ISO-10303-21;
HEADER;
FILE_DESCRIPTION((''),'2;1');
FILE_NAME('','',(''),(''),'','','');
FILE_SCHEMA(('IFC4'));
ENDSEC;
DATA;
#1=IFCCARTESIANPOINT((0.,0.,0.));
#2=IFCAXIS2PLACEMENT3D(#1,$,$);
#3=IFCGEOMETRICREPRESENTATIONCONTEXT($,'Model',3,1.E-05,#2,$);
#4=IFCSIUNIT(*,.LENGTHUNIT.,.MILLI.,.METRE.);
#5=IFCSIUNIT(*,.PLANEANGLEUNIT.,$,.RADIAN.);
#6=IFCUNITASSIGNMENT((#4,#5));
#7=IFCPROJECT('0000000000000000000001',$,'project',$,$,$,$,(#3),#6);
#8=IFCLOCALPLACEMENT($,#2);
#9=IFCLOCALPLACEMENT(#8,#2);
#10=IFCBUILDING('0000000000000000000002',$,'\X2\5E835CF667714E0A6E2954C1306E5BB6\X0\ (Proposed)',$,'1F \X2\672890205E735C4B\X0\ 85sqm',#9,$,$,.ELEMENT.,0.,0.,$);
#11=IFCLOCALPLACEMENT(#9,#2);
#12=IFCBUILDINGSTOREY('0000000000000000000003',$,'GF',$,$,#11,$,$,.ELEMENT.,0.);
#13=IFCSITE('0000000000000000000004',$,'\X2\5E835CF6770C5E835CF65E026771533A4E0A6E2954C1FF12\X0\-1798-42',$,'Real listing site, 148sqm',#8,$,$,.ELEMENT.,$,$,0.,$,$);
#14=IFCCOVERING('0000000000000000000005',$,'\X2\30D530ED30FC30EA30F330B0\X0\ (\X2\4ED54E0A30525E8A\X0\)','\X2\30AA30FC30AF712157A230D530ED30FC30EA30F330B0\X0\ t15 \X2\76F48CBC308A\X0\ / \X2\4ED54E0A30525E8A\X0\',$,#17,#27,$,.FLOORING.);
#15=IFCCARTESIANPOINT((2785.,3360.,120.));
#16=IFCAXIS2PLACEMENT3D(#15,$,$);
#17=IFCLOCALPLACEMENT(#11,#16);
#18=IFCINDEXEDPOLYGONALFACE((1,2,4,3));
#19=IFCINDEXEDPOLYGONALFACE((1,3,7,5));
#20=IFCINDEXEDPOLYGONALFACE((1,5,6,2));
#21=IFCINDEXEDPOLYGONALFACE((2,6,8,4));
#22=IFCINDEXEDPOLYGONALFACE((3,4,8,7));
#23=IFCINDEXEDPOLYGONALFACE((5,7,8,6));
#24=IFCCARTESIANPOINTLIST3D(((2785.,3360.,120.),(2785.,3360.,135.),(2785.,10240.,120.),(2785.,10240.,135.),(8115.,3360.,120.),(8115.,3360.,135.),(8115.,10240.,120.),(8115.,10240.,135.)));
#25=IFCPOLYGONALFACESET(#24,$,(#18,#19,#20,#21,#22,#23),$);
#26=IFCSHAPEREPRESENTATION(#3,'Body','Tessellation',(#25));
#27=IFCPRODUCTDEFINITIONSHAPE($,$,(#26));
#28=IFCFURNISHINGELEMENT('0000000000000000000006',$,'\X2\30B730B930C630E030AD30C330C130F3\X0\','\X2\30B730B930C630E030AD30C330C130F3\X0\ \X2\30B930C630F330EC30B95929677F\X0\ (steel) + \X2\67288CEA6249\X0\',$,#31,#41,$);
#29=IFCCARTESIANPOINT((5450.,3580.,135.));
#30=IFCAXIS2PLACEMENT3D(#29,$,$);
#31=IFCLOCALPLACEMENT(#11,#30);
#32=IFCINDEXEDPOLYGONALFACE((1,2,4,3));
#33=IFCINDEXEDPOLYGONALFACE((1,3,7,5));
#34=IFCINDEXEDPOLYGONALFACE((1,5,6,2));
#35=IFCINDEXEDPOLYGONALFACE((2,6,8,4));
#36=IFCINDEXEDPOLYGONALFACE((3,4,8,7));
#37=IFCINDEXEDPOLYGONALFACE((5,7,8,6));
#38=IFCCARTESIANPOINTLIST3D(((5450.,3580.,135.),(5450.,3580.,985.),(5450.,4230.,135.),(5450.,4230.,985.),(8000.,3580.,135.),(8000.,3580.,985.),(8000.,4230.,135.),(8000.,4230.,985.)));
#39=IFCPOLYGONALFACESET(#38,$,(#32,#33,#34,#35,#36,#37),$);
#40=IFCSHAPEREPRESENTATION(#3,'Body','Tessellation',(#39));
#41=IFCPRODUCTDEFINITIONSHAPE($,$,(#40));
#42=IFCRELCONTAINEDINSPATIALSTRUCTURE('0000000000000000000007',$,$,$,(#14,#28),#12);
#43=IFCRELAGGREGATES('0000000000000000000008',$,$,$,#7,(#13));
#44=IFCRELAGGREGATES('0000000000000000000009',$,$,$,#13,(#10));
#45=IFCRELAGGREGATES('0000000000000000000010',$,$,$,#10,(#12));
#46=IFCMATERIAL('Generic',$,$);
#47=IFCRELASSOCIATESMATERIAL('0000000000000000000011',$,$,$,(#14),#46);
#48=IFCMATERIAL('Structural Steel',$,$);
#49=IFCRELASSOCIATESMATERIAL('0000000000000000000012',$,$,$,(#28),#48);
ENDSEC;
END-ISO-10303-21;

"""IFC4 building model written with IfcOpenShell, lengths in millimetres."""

from ifc_helpers import new_model, si_unit, frame, frame_2d, origin, place, context, project, spatial, rectangle, extrude, material, element, save


model = new_model("IFC4")

# Units and contexts
model_context = context("Model", 3, precision=1e-05, world=origin())
ifc_project = project(units=[si_unit("LENGTHUNIT", "METRE", prefix="MILLI"), si_unit("PLANEANGLEUNIT", "RADIAN")], contexts=[model_context])

# Site, building, storey
site_placement = place(None, origin())
site = spatial("IfcSite", under=ifc_project, at=site_placement, Name="広島県広島市東区上温品２-1798-42", ObjectType="Real listing site, 148sqm", CompositionType="ELEMENT", RefElevation=0.0)
building_placement = place(site_placement, origin())
building = spatial("IfcBuilding", under=site, at=building_placement, Name="広島東上温品の家 (Proposed)", ObjectType="1F 木造平屋 85sqm", CompositionType="ELEMENT", ElevationOfRefHeight=0.0, ElevationOfTerrain=0.0)
storey_placement = place(building_placement, origin())
storey = spatial("IfcBuildingStorey", under=building, at=storey_placement, Name="GF", CompositionType="ELEMENT", Elevation=0.0)

# Shared definitions
ifc_material_1 = material(Name="Generic")

# Covering
covering_placement = place(storey_placement, frame((2785.0, 3360.0, 120.0)))
element("IfcCovering", 1, at=covering_placement, inside=storey, material=ifc_material_1, Name="フローリング (仕上げ床)", Description="オーク無垢フローリング t15 直貼り / 仕上げ床", PredefinedType="FLOORING", context=model_context, shape_type="SweptSolid", body=[
    extrude(rectangle(XDim=5330.0, YDim=6880.0, at=frame_2d((2665.0, 3440.0))), frame((2785.0, 3360.0, 120.0)), (0.0, 0.0, 1.0), 15.0),
])

# Furnishing element
ifc_material_2 = material(Name="Structural Steel")
furnishing_placement = place(storey_placement, frame((5450.0, 3580.0, 135.0)))
element("IfcFurnishingElement", 2, at=furnishing_placement, inside=storey, material=ifc_material_2, Name="システムキッチン", Description="システムキッチン ステンレス天板 (steel) + 木質扉", context=model_context, shape_type="SweptSolid", body=[
    extrude(rectangle(XDim=2550.0, YDim=650.0, at=frame_2d((1275.0, 325.0))), frame((5450.0, 3580.0, 135.0)), (0.0, 0.0, 1.0), 850.0),
])

save(model, "model.ifc")
